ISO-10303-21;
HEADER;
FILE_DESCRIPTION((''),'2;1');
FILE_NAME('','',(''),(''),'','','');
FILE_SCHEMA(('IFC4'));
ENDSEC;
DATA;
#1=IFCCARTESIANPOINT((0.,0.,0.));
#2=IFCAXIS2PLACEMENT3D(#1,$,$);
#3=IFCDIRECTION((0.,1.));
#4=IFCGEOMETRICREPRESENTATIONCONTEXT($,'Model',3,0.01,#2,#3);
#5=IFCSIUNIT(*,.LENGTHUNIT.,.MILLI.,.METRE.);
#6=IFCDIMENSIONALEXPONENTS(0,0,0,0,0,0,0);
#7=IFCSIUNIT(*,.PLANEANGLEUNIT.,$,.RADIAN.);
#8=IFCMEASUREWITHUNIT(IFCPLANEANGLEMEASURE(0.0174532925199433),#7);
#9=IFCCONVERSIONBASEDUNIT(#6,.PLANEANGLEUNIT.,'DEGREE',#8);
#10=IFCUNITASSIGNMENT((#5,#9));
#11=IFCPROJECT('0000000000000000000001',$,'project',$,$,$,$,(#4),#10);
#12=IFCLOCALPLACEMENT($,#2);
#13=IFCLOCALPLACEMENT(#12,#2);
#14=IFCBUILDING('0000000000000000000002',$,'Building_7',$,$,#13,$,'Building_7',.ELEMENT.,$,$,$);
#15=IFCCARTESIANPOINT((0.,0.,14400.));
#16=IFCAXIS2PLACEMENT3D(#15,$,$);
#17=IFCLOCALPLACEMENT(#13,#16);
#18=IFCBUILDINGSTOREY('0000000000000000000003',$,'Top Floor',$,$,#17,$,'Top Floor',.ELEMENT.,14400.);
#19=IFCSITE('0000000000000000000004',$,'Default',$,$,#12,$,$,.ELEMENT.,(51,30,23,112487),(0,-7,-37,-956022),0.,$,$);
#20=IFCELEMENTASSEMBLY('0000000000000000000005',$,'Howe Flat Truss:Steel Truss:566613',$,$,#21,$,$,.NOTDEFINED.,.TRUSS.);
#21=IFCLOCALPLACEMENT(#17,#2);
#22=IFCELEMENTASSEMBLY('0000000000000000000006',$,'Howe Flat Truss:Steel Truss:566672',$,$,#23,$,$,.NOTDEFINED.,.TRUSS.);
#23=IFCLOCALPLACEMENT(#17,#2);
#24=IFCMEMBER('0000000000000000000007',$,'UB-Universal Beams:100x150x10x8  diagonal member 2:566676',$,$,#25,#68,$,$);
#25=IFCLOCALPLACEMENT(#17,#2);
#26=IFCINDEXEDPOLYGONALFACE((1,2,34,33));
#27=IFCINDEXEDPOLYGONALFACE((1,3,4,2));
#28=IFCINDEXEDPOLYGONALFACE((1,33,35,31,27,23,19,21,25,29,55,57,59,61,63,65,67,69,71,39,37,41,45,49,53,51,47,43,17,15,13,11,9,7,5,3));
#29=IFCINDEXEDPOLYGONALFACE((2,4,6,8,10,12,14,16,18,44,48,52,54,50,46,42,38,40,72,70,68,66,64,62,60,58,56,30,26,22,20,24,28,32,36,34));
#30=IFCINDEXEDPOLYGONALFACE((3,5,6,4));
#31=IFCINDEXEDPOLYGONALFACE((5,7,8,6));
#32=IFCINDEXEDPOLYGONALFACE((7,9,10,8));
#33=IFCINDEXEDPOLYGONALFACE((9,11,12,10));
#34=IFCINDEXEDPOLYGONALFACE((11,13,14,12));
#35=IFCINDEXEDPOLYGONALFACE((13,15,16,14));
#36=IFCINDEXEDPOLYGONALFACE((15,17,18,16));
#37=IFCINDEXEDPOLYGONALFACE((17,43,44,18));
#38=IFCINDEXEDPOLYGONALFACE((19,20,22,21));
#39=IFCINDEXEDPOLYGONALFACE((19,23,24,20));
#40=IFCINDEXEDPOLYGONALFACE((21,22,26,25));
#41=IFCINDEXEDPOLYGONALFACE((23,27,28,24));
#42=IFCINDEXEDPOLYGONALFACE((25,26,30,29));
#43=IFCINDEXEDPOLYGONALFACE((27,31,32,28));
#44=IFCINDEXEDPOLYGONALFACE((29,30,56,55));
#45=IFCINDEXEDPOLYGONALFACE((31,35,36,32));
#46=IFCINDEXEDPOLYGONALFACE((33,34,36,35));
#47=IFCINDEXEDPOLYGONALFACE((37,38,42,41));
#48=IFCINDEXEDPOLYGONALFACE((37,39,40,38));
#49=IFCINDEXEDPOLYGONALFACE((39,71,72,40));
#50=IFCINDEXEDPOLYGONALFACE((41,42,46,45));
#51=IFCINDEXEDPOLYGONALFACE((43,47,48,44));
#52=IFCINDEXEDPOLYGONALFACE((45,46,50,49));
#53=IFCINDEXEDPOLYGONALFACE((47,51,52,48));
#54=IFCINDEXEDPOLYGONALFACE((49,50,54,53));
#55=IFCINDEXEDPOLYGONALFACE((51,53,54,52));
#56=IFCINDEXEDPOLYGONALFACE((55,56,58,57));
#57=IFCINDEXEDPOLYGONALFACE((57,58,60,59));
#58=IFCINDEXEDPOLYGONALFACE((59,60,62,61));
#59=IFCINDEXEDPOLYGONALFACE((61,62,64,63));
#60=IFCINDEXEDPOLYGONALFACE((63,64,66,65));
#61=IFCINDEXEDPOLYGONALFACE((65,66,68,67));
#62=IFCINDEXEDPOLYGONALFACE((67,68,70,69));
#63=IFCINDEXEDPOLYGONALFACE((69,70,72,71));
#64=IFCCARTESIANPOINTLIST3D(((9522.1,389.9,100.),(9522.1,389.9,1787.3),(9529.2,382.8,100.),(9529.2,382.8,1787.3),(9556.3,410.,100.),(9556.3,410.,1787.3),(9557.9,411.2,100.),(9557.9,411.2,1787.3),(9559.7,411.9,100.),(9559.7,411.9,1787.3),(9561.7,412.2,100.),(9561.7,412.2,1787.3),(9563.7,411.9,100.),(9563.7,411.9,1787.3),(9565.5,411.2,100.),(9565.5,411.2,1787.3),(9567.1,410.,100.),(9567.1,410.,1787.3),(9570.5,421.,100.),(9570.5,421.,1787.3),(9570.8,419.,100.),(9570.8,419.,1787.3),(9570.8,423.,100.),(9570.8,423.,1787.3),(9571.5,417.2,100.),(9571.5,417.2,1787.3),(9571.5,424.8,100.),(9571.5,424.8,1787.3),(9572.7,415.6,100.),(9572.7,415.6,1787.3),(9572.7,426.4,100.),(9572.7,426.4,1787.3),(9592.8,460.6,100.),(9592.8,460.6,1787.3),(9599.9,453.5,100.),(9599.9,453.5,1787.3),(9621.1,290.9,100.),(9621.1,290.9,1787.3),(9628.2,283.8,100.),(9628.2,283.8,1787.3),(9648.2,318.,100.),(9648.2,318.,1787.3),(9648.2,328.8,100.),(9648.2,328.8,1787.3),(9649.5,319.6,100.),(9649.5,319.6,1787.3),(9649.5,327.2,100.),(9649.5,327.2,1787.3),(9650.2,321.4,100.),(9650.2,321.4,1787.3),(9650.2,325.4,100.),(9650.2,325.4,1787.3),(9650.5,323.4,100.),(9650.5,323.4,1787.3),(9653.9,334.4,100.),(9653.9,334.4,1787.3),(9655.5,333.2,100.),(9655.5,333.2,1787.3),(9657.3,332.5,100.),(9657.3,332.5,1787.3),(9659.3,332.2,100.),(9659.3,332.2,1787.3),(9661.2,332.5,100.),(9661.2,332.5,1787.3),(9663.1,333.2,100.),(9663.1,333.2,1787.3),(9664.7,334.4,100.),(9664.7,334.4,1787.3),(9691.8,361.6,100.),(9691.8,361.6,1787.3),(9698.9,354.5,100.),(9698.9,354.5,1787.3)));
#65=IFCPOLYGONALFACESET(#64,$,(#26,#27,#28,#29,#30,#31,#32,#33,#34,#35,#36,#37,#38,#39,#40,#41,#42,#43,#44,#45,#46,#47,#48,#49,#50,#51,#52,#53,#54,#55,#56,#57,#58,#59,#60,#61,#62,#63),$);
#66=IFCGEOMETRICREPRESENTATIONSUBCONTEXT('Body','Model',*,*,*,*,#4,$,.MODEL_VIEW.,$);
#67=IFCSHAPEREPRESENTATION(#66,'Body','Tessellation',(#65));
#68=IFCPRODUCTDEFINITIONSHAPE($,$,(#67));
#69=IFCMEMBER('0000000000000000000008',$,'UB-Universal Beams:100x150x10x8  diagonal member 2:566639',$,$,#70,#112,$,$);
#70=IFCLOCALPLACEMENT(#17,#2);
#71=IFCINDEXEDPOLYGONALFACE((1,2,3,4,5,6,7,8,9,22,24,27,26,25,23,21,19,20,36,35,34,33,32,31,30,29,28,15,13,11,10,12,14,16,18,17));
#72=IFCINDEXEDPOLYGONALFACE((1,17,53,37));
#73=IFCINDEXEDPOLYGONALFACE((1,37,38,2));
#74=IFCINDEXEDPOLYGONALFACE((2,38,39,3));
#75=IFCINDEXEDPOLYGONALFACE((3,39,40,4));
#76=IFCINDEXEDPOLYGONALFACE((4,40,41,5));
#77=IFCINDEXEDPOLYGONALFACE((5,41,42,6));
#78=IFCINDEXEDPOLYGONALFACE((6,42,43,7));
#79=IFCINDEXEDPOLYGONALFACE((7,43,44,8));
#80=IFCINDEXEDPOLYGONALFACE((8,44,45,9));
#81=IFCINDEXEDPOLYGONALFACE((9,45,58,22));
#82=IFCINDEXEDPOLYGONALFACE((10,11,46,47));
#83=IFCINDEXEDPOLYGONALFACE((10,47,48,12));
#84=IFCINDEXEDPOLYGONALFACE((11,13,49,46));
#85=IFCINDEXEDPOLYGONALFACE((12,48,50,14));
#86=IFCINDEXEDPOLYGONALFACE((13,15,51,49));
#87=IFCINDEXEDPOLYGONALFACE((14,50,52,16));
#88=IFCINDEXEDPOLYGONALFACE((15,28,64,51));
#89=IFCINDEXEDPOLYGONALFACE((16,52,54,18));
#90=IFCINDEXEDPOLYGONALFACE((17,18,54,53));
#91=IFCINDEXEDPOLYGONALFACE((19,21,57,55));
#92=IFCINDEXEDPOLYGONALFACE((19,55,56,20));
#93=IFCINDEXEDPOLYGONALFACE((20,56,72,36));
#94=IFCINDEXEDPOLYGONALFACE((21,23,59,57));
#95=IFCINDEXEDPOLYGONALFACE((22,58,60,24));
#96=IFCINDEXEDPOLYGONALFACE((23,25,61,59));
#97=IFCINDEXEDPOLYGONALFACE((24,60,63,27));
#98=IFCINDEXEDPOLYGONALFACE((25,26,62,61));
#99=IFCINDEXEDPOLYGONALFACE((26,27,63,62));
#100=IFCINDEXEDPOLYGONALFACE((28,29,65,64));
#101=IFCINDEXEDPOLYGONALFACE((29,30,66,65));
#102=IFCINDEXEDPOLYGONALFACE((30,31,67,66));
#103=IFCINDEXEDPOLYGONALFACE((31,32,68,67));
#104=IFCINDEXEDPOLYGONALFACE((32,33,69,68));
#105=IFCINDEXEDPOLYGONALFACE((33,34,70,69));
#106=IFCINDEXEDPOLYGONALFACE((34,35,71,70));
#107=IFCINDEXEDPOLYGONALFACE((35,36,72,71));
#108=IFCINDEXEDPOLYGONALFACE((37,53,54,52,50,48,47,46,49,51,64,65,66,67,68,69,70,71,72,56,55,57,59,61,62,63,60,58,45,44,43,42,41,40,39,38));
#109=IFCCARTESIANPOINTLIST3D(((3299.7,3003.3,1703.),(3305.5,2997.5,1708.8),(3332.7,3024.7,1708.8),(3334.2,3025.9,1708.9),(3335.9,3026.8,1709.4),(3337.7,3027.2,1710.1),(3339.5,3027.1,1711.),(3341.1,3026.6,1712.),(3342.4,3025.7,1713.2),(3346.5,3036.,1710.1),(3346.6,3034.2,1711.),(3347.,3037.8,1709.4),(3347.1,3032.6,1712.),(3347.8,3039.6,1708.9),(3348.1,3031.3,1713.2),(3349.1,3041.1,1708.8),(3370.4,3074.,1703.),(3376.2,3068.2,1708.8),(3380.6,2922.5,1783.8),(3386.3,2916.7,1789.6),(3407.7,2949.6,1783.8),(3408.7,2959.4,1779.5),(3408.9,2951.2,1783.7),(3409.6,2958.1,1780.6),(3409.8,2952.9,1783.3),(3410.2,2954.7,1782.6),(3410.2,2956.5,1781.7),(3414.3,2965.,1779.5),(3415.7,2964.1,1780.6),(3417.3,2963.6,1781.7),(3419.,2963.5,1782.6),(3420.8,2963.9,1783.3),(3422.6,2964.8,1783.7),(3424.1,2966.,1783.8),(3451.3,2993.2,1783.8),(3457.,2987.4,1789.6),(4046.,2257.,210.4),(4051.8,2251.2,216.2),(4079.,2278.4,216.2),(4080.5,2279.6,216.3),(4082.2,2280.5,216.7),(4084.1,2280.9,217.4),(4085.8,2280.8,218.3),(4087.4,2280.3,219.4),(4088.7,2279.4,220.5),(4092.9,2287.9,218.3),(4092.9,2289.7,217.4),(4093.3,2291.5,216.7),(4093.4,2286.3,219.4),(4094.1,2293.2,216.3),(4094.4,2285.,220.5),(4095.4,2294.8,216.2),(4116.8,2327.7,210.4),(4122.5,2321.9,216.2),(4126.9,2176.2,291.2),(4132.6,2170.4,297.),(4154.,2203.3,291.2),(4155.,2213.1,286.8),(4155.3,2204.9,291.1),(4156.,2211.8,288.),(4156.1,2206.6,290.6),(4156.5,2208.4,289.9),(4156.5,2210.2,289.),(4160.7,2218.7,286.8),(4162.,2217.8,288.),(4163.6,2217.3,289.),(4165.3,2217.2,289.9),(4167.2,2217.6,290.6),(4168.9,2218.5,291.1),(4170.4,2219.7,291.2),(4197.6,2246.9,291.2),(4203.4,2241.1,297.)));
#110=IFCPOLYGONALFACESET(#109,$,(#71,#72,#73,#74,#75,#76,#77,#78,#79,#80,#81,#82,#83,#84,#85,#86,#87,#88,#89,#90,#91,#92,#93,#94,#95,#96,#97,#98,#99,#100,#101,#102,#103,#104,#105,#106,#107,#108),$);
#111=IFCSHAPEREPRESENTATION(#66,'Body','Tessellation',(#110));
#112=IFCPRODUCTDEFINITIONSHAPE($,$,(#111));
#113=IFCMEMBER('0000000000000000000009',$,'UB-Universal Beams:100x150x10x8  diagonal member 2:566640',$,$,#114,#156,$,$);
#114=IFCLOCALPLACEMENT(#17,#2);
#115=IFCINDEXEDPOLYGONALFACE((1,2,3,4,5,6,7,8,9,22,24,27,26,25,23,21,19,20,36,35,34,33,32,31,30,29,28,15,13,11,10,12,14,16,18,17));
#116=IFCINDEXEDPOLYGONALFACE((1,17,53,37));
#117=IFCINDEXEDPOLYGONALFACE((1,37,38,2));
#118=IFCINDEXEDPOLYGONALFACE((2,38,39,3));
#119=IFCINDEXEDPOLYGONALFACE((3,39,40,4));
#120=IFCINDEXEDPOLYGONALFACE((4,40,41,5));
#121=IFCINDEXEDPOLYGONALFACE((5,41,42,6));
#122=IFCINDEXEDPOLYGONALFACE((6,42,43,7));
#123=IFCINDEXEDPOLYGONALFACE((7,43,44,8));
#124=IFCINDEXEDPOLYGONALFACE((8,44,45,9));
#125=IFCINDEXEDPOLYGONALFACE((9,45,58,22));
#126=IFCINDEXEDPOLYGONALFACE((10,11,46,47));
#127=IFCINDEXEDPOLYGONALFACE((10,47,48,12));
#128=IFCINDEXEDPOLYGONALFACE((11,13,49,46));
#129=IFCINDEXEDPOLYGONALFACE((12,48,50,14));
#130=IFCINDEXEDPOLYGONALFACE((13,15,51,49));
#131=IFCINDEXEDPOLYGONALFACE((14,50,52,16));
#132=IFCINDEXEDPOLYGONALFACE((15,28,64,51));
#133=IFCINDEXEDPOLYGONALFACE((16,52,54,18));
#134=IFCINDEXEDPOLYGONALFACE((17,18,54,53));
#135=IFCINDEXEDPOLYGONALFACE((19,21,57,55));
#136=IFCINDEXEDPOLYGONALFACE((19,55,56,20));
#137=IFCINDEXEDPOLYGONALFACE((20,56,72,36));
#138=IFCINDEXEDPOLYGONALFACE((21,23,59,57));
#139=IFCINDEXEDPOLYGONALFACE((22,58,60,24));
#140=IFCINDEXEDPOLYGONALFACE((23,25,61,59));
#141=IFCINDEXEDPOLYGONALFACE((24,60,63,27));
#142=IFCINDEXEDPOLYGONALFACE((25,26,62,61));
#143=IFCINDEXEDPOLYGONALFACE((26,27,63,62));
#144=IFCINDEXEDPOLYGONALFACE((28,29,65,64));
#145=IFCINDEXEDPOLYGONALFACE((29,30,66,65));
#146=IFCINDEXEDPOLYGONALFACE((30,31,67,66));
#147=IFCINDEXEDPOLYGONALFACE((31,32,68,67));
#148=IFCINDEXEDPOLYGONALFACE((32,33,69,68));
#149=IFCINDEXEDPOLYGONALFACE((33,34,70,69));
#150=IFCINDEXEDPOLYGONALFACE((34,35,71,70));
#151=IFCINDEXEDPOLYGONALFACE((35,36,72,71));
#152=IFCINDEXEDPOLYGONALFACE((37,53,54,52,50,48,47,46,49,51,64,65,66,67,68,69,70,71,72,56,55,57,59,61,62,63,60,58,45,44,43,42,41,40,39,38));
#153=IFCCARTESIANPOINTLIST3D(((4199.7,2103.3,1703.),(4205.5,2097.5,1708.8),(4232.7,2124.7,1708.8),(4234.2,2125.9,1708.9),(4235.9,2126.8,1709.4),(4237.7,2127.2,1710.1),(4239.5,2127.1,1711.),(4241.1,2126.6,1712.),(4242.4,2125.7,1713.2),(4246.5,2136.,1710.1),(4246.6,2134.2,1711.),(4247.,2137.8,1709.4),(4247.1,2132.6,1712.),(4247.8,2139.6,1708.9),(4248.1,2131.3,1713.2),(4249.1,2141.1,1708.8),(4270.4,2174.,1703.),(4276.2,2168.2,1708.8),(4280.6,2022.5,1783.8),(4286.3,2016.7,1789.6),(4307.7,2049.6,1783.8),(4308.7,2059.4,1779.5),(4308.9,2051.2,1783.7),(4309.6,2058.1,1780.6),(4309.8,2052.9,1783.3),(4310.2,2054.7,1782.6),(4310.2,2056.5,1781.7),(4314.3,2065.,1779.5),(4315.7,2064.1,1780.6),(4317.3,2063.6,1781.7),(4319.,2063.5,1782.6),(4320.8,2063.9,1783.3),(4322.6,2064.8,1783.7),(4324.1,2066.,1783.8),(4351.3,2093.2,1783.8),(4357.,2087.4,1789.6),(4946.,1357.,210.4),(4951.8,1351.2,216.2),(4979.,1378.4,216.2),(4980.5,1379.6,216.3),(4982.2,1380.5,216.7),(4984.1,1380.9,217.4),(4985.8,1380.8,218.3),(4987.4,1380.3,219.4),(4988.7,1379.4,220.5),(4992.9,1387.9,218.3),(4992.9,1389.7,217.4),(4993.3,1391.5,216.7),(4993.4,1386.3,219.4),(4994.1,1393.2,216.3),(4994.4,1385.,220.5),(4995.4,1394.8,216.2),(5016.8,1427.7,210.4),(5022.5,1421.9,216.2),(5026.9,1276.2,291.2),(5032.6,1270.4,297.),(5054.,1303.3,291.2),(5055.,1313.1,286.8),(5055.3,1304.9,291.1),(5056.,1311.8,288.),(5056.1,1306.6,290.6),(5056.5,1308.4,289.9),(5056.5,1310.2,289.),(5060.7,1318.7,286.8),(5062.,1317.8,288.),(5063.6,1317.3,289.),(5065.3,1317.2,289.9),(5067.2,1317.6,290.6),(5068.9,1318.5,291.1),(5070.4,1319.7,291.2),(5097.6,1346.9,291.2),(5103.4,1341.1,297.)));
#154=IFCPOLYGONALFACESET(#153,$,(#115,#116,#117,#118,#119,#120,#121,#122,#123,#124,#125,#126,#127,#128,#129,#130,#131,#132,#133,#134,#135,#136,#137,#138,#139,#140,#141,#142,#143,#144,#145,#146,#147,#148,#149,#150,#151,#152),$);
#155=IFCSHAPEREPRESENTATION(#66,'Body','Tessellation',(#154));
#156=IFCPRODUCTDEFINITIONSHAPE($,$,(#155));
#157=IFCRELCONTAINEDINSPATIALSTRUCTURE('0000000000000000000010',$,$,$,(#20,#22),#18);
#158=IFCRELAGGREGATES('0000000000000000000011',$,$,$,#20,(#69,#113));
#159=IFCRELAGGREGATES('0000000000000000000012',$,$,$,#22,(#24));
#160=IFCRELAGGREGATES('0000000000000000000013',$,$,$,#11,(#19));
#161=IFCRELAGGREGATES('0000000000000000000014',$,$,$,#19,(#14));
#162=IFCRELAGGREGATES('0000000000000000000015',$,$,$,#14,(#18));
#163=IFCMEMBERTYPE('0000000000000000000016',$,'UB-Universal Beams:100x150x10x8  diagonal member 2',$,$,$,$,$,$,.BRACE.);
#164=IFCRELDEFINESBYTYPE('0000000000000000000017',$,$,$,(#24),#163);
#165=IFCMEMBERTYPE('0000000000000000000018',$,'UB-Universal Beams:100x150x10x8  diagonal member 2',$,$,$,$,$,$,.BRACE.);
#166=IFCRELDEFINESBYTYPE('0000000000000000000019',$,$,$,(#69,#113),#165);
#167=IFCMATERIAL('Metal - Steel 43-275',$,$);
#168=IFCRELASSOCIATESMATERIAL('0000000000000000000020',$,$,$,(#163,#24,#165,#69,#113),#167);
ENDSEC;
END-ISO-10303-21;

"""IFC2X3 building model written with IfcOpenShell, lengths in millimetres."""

from ifc_helpers import new_model, entity, si_unit, converted_unit, direction, frame, frame_2d, origin, place, context, subcontext, project, spatial, polyline, circle_curve, parameter, trimmed, segment, composite_curve, outline, extrude, source, transform, mapped, material, type_object, type_shapes, element, aggregate, save


model = new_model("IFC2X3")

# Units and contexts
model_context = context("Model", 3, precision=0.01, world=origin(), true_north=direction((0.0, 1.0)))
body_context = subcontext(model_context, "Body", "Model", "MODEL_VIEW")
ifc_project = project(units=[si_unit("LENGTHUNIT", "METRE", prefix="MILLI"), converted_unit("PLANEANGLEUNIT", "DEGREE", entity("IfcPlaneAngleMeasure", 0.0174532925199433), si_unit("PLANEANGLEUNIT", "RADIAN"), dimensions=[0, 0, 0, 0, 0, 0, 0])], contexts=[model_context])

# Site, building, storey
site_placement = place(None, origin())
site = spatial("IfcSite", under=ifc_project, at=site_placement, Name="Default", CompositionType="ELEMENT", RefLatitude=(51, 30, 23, 112487), RefLongitude=(0, -7, -37, -956022), RefElevation=0.0)
building_placement = place(site_placement, origin())
building = spatial("IfcBuilding", under=site, at=building_placement, Name="Building_7", LongName="Building_7", CompositionType="ELEMENT")
storey_placement = place(building_placement, frame((0.0, 0.0, 14400.0)))
storey = spatial("IfcBuildingStorey", under=building, at=storey_placement, Name="Top Floor", LongName="Top Floor", CompositionType="ELEMENT", Elevation=14400.0)

# Shared definitions
ifc_material = material(Name="Metal - Steel 43-275")

# Element assemblies
assembly_1_placement = place(storey_placement, origin())
assembly_1 = element("IfcElementAssembly", 1, at=assembly_1_placement, inside=storey, Name="Howe Flat Truss:Steel Truss:566613", AssemblyPlace="NOTDEFINED", PredefinedType="TRUSS")
assembly_2_placement = place(storey_placement, origin())
assembly_2 = element("IfcElementAssembly", 2, at=assembly_2_placement, inside=storey, Name="Howe Flat Truss:Steel Truss:566672", AssemblyPlace="NOTDEFINED", PredefinedType="TRUSS")

# Members
member_type_1 = type_object("IfcMemberType", Name="UB-Universal Beams:100x150x10x8  diagonal member 2", PredefinedType="BRACE", material=ifc_material)
shared_shape_1 = source(origin(), body_context, "Body", "SweptSolid", [
    extrude(outline(composite_curve([segment(polyline([(-50.0, -65.0), (-50.0, -75.0)]), True, "CONTINUOUS"), segment(polyline([(-50.0, -75.0), (50.0, -75.0)]), True, "CONTINUOUS"), segment(polyline([(50.0, -75.0), (50.0, -65.0)]), True, "CONTINUOUS"), segment(polyline([(50.0, -65.0), (11.6, -65.0)]), True, "CONTINUOUS"), segment(trimmed(circle_curve(frame_2d((11.6, -57.4), x_axis=(1.0, 0.0)), 7.6), [parameter(180.0)], [parameter(270.0)], True, "PARAMETER"), False, "CONTINUOUS"), segment(polyline([(4.0, -57.4), (4.0, 57.4)]), True, "CONTINUOUS"), segment(trimmed(circle_curve(frame_2d((11.6, 57.4), x_axis=(1.0, 0.0)), 7.6), [parameter(90.0)], [parameter(180.0)], True, "PARAMETER"), False, "CONTINUOUS"), segment(polyline([(11.6, 65.0), (50.0, 65.0)]), True, "CONTINUOUS"), segment(polyline([(50.0, 65.0), (50.0, 75.0)]), True, "CONTINUOUS"), segment(polyline([(50.0, 75.0), (-50.0, 75.0)]), True, "CONTINUOUS"), segment(polyline([(-50.0, 75.0), (-50.0, 65.0)]), True, "CONTINUOUS"), segment(polyline([(-50.0, 65.0), (-11.6, 65.0)]), True, "CONTINUOUS"), segment(trimmed(circle_curve(frame_2d((-11.6, 57.4), x_axis=(1.0, 0.0)), 7.6), [parameter(360.0)], [parameter(90.0)], True, "PARAMETER"), False, "CONTINUOUS"), segment(polyline([(-4.0, 57.4), (-4.0, -57.4)]), True, "CONTINUOUS"), segment(trimmed(circle_curve(frame_2d((-11.6, -57.4), x_axis=(1.0, 0.0)), 7.6), [parameter(270.0)], [parameter(360.0)], True, "PARAMETER"), False, "CONTINUOUS"), segment(polyline([(-11.6, -65.0), (-50.0, -65.0)]), True, "CONTINUOUS")], self_intersect=False)), frame((-900.0, 0.0, 0.0), z_axis=(-1.0, 0.0, 0.0), x_axis=(0.0, -1.0, 0.0)), (0.0, 0.0, -1.0), 1687.3),
])
type_shapes(member_type_1, [shared_shape_1])
member_1_placement = place(assembly_2_placement, frame((9610.5, 372.2, 1000.0), z_axis=(-0.707107, 0.707107, 0.0), x_axis=(0.0, 0.0, 1.0)))
member_1 = element("IfcMember", 3, at=member_1_placement, type_object=member_type_1, material=ifc_material, Name="UB-Universal Beams:100x150x10x8  diagonal member 2:566676", context=body_context, shape_type="MappedRepresentation", body=[
    mapped(shared_shape_1, transform((0.0, 0.0, 0.0), scale=1.0)),
])
member_type_2 = type_object("IfcMemberType", Name="UB-Universal Beams:100x150x10x8  diagonal member 2", PredefinedType="BRACE", material=ifc_material)
shared_shape_2 = source(origin(), body_context, "Body", "SweptSolid", [
    extrude(outline(composite_curve([segment(polyline([(-50.0, -65.0), (-50.0, -75.0)]), True, "CONTINUOUS"), segment(polyline([(-50.0, -75.0), (50.0, -75.0)]), True, "CONTINUOUS"), segment(polyline([(50.0, -75.0), (50.0, -65.0)]), True, "CONTINUOUS"), segment(polyline([(50.0, -65.0), (11.6, -65.0)]), True, "CONTINUOUS"), segment(trimmed(circle_curve(frame_2d((11.6, -57.4), x_axis=(1.0, 0.0)), 7.6), [parameter(180.0)], [parameter(270.0)], True, "PARAMETER"), False, "CONTINUOUS"), segment(polyline([(4.0, -57.4), (4.0, 57.4)]), True, "CONTINUOUS"), segment(trimmed(circle_curve(frame_2d((11.6, 57.4), x_axis=(1.0, 0.0)), 7.6), [parameter(90.0)], [parameter(180.0)], True, "PARAMETER"), False, "CONTINUOUS"), segment(polyline([(11.6, 65.0), (50.0, 65.0)]), True, "CONTINUOUS"), segment(polyline([(50.0, 65.0), (50.0, 75.0)]), True, "CONTINUOUS"), segment(polyline([(50.0, 75.0), (-50.0, 75.0)]), True, "CONTINUOUS"), segment(polyline([(-50.0, 75.0), (-50.0, 65.0)]), True, "CONTINUOUS"), segment(polyline([(-50.0, 65.0), (-11.6, 65.0)]), True, "CONTINUOUS"), segment(trimmed(circle_curve(frame_2d((-11.6, 57.4), x_axis=(1.0, 0.0)), 7.6), [parameter(360.0)], [parameter(90.0)], True, "PARAMETER"), False, "CONTINUOUS"), segment(polyline([(-4.0, 57.4), (-4.0, -57.4)]), True, "CONTINUOUS"), segment(trimmed(circle_curve(frame_2d((-11.6, -57.4), x_axis=(1.0, 0.0)), 7.6), [parameter(270.0)], [parameter(360.0)], True, "PARAMETER"), False, "CONTINUOUS"), segment(polyline([(-11.6, -65.0), (-50.0, -65.0)]), True, "CONTINUOUS")], self_intersect=False)), frame((-914.0, 0.0, 0.0), z_axis=(-1.0, 0.0, 0.0), x_axis=(0.0, -1.0, 0.0)), (0.0, 0.0, -1.0), 1828.1),
])
type_shapes(member_type_2, [shared_shape_2])
member_2_placement = place(assembly_1_placement, frame((3751.5, 2622.2, 1000.0), z_axis=(-0.57735, 0.57735, -0.57735), x_axis=(0.408248, -0.408248, -0.816497)))
member_2 = element("IfcMember", 4, at=member_2_placement, type_object=member_type_2, material=ifc_material, Name="UB-Universal Beams:100x150x10x8  diagonal member 2:566639", context=body_context, shape_type="MappedRepresentation", body=[
    mapped(shared_shape_2, transform((0.0, 0.0, 0.0), scale=1.0)),
])
member_3_placement = place(assembly_1_placement, frame((4651.5, 1722.2, 1000.0), z_axis=(-0.57735, 0.57735, -0.57735), x_axis=(0.408248, -0.408248, -0.816497)))
member_3 = element("IfcMember", 5, at=member_3_placement, type_object=member_type_2, material=ifc_material, Name="UB-Universal Beams:100x150x10x8  diagonal member 2:566640", context=body_context, shape_type="MappedRepresentation", body=[
    mapped(shared_shape_2, transform((0.0, 0.0, 0.0), scale=1.0)),
])
aggregate(assembly_1, [member_2, member_3])
aggregate(assembly_2, [member_1])

save(model, "model.ifc")
